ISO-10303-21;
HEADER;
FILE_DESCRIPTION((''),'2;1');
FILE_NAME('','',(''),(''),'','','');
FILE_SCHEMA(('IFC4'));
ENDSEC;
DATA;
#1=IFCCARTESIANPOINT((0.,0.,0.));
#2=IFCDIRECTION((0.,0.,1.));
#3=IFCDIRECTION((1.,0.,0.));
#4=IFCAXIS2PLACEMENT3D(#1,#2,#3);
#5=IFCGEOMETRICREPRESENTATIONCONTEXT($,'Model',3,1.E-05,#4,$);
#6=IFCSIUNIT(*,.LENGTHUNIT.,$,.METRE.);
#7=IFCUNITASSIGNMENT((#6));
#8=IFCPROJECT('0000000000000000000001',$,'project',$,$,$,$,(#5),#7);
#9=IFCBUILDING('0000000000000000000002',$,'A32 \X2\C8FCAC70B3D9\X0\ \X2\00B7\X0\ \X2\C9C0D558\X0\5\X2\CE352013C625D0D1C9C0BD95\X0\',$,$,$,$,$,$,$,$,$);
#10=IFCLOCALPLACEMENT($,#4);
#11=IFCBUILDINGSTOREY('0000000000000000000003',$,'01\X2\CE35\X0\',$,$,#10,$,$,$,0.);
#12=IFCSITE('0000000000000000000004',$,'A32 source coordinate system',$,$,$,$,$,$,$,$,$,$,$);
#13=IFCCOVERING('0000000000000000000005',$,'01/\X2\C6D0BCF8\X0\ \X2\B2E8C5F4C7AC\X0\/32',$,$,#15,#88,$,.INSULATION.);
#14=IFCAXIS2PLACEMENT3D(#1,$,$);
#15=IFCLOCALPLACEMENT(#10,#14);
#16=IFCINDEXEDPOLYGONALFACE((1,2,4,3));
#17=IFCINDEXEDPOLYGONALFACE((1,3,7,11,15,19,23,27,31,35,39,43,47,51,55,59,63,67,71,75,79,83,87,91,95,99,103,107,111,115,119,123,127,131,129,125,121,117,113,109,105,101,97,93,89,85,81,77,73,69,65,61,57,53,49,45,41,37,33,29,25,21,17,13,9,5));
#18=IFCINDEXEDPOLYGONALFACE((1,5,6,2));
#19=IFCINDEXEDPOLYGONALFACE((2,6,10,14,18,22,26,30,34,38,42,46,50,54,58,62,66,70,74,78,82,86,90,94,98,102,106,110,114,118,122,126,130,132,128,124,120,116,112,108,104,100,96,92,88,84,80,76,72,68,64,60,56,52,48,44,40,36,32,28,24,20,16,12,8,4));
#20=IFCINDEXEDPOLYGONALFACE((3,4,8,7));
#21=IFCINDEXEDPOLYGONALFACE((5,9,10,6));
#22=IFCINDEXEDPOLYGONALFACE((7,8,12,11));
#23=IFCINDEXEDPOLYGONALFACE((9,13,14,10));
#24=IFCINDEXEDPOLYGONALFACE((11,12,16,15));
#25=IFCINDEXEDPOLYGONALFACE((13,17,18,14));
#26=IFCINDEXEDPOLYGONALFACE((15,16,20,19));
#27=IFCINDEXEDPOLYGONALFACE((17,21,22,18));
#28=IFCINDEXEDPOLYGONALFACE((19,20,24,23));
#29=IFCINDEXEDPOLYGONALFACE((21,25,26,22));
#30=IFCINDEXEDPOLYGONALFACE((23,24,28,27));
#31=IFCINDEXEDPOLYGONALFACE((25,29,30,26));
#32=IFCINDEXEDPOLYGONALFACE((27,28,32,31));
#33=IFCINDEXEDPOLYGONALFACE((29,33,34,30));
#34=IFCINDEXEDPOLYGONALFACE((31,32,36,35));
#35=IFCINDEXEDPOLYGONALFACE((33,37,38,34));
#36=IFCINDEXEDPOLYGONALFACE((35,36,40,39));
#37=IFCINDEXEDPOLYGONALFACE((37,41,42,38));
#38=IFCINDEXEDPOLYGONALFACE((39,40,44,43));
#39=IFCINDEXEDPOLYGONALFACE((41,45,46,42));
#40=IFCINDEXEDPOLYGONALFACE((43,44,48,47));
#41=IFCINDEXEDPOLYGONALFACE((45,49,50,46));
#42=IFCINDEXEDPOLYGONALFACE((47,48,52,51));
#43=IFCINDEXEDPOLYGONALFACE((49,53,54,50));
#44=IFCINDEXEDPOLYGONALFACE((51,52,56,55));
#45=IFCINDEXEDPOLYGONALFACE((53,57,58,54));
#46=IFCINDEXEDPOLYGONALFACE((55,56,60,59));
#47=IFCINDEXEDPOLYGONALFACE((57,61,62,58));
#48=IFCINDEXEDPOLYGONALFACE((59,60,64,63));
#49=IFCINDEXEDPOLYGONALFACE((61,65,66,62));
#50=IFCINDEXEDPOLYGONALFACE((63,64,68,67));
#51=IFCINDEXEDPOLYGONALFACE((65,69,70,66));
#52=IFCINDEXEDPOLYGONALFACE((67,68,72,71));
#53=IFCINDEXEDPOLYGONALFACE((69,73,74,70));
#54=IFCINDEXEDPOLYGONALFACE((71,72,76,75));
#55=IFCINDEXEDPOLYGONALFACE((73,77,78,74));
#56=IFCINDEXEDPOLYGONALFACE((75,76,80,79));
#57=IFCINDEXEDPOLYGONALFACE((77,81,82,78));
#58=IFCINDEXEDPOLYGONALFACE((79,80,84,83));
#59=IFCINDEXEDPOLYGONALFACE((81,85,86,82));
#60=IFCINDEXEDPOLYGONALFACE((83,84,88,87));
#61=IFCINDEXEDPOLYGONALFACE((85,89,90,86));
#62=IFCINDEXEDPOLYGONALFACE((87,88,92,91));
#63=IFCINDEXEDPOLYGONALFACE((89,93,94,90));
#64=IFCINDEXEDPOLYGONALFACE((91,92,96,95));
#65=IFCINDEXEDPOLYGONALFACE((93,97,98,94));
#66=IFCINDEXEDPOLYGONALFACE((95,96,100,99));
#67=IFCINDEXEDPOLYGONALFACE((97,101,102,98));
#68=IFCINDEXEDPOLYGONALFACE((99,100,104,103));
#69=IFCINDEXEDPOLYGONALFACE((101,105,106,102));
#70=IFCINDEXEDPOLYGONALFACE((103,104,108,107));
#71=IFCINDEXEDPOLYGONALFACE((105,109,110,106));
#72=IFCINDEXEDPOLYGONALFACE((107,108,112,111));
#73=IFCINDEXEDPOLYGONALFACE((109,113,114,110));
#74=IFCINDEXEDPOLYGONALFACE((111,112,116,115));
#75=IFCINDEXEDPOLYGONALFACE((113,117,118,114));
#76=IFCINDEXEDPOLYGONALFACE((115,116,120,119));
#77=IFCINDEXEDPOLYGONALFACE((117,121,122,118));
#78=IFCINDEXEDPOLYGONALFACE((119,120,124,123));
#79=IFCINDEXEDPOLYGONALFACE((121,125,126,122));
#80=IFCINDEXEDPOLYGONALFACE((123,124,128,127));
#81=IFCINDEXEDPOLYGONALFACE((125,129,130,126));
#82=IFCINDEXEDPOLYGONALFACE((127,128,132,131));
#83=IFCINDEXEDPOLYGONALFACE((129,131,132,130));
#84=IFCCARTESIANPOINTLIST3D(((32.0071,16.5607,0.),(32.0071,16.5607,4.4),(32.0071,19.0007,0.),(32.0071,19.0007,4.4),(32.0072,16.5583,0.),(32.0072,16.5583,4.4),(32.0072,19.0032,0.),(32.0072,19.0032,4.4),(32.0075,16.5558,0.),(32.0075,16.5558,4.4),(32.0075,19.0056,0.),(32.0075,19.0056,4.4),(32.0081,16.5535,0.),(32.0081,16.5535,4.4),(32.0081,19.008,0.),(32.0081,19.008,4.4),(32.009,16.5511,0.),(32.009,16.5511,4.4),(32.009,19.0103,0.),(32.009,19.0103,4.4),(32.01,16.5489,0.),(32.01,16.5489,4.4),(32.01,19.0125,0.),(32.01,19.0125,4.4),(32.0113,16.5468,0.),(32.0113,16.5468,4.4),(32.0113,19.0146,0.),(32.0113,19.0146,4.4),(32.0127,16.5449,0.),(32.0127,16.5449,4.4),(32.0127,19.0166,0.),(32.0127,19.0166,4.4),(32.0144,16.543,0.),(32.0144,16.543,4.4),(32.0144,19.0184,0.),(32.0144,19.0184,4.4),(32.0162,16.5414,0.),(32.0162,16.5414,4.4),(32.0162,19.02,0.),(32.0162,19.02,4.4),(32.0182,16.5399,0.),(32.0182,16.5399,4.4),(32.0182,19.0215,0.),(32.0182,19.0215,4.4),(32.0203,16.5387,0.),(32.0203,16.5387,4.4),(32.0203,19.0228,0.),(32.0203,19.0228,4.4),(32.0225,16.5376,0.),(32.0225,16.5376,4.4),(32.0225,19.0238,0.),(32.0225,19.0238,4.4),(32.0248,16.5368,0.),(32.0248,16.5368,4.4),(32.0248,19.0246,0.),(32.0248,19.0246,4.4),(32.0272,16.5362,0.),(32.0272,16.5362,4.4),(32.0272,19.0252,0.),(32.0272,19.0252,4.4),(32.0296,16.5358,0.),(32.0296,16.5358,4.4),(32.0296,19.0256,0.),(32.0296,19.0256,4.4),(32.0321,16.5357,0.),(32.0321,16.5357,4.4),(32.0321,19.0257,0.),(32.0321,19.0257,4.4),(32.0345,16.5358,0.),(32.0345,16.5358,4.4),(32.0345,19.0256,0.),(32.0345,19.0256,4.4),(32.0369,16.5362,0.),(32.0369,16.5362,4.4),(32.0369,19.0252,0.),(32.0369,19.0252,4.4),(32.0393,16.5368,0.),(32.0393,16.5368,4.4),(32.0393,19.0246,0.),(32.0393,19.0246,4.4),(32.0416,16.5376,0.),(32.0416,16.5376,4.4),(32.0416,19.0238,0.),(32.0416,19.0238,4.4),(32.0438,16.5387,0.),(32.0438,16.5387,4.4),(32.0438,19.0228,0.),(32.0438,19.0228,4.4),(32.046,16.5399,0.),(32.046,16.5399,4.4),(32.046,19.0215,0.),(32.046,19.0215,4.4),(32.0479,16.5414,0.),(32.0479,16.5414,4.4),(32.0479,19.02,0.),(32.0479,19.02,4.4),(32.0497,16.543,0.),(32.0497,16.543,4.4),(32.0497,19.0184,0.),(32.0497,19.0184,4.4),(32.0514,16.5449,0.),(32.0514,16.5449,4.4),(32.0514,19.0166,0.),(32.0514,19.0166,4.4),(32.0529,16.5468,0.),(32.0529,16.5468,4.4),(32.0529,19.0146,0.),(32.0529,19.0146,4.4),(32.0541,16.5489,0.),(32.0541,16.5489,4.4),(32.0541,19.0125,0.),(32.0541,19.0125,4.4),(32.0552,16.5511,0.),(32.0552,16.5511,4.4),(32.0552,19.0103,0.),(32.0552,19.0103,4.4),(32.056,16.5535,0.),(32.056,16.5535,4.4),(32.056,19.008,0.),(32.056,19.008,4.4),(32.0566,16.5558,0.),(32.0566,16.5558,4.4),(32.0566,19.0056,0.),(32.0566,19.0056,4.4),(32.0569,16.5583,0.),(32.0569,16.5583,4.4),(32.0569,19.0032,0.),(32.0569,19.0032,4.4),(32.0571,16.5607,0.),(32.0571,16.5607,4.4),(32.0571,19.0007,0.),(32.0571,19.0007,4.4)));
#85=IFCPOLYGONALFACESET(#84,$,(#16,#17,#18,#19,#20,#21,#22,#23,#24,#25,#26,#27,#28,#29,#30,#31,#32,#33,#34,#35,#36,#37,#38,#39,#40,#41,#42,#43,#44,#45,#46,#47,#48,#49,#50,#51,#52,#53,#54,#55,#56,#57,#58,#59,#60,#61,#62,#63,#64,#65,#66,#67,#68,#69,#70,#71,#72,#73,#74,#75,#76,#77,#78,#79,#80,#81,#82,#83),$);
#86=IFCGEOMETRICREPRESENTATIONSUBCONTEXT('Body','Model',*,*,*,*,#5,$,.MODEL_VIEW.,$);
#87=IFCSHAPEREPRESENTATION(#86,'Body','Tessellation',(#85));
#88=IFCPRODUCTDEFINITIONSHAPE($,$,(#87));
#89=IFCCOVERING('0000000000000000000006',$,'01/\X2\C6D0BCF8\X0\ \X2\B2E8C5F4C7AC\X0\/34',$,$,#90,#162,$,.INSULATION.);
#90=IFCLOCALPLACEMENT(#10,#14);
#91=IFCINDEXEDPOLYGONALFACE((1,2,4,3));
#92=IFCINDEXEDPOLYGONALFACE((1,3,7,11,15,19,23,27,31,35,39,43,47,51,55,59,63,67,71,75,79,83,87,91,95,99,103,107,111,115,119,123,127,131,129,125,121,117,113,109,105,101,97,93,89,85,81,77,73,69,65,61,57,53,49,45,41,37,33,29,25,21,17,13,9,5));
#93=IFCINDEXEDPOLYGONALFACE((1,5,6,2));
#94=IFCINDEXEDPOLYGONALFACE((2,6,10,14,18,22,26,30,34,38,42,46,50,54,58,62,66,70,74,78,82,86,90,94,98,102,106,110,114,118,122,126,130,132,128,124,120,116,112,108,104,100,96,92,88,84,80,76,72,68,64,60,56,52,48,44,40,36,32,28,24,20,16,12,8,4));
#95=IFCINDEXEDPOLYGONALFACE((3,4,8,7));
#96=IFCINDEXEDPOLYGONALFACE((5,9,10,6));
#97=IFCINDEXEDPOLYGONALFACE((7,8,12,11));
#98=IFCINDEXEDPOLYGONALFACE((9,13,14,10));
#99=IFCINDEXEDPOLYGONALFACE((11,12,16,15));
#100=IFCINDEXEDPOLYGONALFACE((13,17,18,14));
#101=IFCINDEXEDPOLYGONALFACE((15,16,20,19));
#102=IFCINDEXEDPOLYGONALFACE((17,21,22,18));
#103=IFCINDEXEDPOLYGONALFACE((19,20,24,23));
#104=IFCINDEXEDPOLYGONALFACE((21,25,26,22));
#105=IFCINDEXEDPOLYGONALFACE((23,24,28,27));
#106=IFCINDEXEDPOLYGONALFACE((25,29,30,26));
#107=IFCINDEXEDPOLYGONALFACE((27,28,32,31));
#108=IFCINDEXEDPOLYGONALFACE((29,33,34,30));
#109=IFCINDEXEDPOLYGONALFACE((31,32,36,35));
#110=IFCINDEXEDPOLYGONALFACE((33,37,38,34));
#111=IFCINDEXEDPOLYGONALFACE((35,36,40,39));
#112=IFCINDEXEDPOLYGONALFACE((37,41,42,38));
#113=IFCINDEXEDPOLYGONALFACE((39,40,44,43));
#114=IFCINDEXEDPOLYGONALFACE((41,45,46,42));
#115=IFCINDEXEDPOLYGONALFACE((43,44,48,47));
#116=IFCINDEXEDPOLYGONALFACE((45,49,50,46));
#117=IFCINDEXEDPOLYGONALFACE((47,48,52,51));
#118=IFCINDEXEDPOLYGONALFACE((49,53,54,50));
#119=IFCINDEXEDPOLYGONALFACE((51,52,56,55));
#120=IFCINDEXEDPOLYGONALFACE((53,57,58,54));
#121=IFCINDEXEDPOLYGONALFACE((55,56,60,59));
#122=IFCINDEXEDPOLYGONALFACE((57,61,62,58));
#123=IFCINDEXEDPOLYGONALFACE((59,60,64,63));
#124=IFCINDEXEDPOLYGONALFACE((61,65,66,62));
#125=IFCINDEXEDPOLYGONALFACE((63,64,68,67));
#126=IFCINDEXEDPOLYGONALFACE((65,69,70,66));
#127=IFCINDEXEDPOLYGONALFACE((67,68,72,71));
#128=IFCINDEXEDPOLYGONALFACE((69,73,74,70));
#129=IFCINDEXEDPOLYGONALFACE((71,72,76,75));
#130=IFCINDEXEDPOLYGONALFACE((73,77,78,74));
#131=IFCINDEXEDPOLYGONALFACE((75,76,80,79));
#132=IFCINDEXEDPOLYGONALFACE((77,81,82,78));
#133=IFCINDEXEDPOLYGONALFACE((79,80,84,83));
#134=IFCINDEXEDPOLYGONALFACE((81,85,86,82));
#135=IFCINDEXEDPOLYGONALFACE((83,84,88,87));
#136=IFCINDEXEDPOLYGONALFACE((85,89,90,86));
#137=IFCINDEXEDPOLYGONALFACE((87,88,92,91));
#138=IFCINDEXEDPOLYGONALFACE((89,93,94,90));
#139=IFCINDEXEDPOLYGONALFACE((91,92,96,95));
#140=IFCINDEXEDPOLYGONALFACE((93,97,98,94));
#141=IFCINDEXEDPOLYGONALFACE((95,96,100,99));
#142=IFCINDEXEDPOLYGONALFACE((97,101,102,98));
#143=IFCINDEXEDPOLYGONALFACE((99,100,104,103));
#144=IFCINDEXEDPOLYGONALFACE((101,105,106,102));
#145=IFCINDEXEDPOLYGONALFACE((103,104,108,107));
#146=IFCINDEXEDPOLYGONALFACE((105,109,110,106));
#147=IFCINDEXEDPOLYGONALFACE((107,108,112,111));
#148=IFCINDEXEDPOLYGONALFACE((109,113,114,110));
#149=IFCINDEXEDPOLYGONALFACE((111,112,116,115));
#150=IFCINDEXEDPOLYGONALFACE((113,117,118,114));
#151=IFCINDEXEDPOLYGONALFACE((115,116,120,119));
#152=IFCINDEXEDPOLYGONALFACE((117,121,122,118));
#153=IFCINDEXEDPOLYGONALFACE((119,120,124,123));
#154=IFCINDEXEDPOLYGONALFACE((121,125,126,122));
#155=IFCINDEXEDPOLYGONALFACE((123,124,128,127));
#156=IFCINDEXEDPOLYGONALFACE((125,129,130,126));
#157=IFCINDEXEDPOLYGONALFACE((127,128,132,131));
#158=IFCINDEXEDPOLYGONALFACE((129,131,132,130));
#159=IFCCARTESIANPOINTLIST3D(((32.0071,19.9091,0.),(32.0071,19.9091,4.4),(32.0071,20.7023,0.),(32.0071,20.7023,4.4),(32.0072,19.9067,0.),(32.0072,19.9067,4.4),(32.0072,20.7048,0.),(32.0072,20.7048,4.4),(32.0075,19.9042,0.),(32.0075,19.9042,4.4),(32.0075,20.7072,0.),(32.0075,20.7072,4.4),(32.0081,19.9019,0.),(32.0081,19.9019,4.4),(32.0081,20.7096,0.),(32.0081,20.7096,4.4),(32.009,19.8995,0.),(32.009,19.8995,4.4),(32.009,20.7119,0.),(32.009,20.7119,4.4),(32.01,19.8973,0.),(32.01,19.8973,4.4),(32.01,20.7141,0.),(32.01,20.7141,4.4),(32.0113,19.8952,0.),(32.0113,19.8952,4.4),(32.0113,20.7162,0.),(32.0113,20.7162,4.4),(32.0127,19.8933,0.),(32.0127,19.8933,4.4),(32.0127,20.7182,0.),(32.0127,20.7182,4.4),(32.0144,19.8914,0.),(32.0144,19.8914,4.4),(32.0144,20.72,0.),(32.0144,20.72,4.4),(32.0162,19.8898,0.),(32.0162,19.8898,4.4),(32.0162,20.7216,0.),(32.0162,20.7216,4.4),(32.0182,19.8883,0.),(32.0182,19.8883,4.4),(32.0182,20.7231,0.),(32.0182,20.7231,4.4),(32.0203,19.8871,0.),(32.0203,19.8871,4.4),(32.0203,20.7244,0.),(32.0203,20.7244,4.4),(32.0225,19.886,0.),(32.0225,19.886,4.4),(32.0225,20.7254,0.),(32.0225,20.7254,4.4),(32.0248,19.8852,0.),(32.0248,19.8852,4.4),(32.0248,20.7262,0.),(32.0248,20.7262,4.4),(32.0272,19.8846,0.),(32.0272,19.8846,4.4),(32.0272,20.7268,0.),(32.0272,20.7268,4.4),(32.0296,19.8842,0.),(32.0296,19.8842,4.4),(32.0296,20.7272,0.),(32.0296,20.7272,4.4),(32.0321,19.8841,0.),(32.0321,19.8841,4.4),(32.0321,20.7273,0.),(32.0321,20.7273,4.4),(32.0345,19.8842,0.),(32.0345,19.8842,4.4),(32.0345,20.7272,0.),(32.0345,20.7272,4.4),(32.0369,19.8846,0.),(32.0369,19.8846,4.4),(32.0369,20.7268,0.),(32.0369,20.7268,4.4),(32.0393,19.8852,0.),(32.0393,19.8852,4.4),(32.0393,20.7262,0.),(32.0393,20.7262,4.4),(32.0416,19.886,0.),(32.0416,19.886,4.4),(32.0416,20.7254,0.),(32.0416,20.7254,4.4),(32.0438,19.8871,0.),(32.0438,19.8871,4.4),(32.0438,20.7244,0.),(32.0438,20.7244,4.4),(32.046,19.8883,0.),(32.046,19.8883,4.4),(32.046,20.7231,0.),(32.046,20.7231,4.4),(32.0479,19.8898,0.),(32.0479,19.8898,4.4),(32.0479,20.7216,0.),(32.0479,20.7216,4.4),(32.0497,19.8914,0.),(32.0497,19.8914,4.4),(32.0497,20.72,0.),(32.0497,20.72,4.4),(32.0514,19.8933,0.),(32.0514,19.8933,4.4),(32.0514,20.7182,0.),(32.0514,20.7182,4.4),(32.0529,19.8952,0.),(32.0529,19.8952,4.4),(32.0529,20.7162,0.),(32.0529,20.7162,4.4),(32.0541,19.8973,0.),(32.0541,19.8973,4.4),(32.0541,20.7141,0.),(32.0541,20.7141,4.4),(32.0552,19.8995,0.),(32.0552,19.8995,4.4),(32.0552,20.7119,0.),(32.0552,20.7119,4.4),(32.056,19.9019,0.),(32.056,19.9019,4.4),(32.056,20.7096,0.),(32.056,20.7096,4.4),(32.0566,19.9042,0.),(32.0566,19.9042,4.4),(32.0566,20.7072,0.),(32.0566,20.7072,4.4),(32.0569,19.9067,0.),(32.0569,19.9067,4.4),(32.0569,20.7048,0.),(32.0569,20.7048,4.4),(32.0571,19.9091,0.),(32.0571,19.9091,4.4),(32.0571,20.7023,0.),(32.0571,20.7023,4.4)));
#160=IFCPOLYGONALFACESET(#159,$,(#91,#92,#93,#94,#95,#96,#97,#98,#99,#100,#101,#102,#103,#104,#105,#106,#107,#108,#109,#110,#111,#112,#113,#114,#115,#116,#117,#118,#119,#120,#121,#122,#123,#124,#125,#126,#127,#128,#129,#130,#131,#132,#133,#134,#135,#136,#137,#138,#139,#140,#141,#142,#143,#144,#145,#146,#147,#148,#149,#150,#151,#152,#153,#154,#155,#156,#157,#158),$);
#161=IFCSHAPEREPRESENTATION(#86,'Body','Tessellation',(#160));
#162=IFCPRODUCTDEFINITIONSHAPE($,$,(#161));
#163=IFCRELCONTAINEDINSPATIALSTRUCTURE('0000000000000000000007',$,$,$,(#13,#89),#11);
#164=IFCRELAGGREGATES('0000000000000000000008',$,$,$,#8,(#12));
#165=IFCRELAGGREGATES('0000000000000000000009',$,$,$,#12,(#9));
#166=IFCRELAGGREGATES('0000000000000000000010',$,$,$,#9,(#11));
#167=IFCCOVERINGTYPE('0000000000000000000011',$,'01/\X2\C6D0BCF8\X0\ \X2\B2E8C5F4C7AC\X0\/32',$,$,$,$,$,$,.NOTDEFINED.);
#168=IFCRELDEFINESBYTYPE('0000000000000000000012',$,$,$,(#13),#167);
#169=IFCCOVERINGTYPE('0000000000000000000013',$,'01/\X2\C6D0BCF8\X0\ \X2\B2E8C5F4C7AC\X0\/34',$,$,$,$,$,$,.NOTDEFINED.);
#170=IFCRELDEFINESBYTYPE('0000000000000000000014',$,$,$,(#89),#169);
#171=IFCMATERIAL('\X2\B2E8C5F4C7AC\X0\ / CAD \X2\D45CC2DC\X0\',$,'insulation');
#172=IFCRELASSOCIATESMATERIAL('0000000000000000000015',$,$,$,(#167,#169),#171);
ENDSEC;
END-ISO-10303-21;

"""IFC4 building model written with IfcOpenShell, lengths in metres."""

from ifc_helpers import new_model, si_unit, origin, origin_with_axes, place, context, subcontext, project, spatial, polyline, outline, extrude, source, transform, mapped, material, type_object, type_shapes, element, save


model = new_model("IFC4")

# Units and contexts
model_context = context("Model", 3, precision=1e-05, world=origin_with_axes())
body_context = subcontext(model_context, "Body", "Model", "MODEL_VIEW")
ifc_project = project(units=[si_unit("LENGTHUNIT", "METRE")], contexts=[model_context])

# Site, building, storey
site = spatial("IfcSite", under=ifc_project, Name="A32 source coordinate system")
building = spatial("IfcBuilding", under=site, Name="A32 주거동 · 지하5층–옥탑지붕")
storey_placement = place(None, origin_with_axes())
storey = spatial("IfcBuildingStorey", under=building, at=storey_placement, Name="01층", Elevation=0.0)

# Coverings
ifc_material = material(Name="단열재 / CAD 표시", Category="insulation")
covering_type_1 = type_object("IfcCoveringType", Name="01/원본 단열재/32", PredefinedType="NOTDEFINED", material=ifc_material)
shared_shape_1 = source(origin(), body_context, "Body", "SweptSolid", [
    extrude(outline(polyline([(32.0541, 16.5489), (32.0529, 16.5468), (32.0514, 16.5449), (32.0497, 16.543), (32.0479, 16.5414), (32.046, 16.5399), (32.0438, 16.5387), (32.0416, 16.5376), (32.0393, 16.5368), (32.0369, 16.5362), (32.0345, 16.5358), (32.0321, 16.5357), (32.0296, 16.5358), (32.0272, 16.5362), (32.0248, 16.5368), (32.0225, 16.5376), (32.0203, 16.5387), (32.0182, 16.5399), (32.0162, 16.5414), (32.0144, 16.543), (32.0127, 16.5449), (32.0113, 16.5468), (32.01, 16.5489), (32.009, 16.5511), (32.0081, 16.5535), (32.0075, 16.5558), (32.0072, 16.5583), (32.0071, 16.5607), (32.0071, 19.0007), (32.0072, 19.0032), (32.0075, 19.0056), (32.0081, 19.008), (32.009, 19.0103), (32.01, 19.0125), (32.0113, 19.0146), (32.0127, 19.0166), (32.0144, 19.0184), (32.0162, 19.02), (32.0182, 19.0215), (32.0203, 19.0228), (32.0225, 19.0238), (32.0248, 19.0246), (32.0272, 19.0252), (32.0296, 19.0256), (32.0321, 19.0257), (32.0345, 19.0256), (32.0369, 19.0252), (32.0393, 19.0246), (32.0416, 19.0238), (32.0438, 19.0228), (32.046, 19.0215), (32.0479, 19.02), (32.0497, 19.0184), (32.0514, 19.0166), (32.0529, 19.0146), (32.0541, 19.0125), (32.0552, 19.0103), (32.056, 19.008), (32.0566, 19.0056), (32.0569, 19.0032), (32.0571, 19.0007), (32.0571, 16.5607), (32.0569, 16.5583), (32.0566, 16.5558), (32.056, 16.5535), (32.0552, 16.5511), (32.0541, 16.5489)])), origin(), (0.0, 0.0, 1.0), 4.4),
])
type_shapes(covering_type_1, [shared_shape_1])
covering_1_placement = place(storey_placement, origin_with_axes())
element("IfcCovering", 1, at=covering_1_placement, inside=storey, type_object=covering_type_1, Name="01/원본 단열재/32", PredefinedType="INSULATION", context=body_context, shape_type="MappedRepresentation", body=[
    mapped(shared_shape_1, transform((0.0, 0.0, 0.0), scale=1.0)),
])
covering_type_2 = type_object("IfcCoveringType", Name="01/원본 단열재/34", PredefinedType="NOTDEFINED", material=ifc_material)
shared_shape_2 = source(origin(), body_context, "Body", "SweptSolid", [
    extrude(outline(polyline([(32.0113, 20.7162), (32.0127, 20.7182), (32.0144, 20.72), (32.0162, 20.7216), (32.0182, 20.7231), (32.0203, 20.7244), (32.0225, 20.7254), (32.0248, 20.7262), (32.0272, 20.7268), (32.0296, 20.7272), (32.0321, 20.7273), (32.0345, 20.7272), (32.0369, 20.7268), (32.0393, 20.7262), (32.0416, 20.7254), (32.0438, 20.7244), (32.046, 20.7231), (32.0479, 20.7216), (32.0497, 20.72), (32.0514, 20.7182), (32.0529, 20.7162), (32.0541, 20.7141), (32.0552, 20.7119), (32.056, 20.7096), (32.0566, 20.7072), (32.0569, 20.7048), (32.0571, 20.7023), (32.0571, 19.9091), (32.0569, 19.9067), (32.0566, 19.9042), (32.056, 19.9019), (32.0552, 19.8995), (32.0541, 19.8973), (32.0529, 19.8952), (32.0514, 19.8933), (32.0497, 19.8914), (32.0479, 19.8898), (32.046, 19.8883), (32.0438, 19.8871), (32.0416, 19.886), (32.0393, 19.8852), (32.0369, 19.8846), (32.0345, 19.8842), (32.0321, 19.8841), (32.0296, 19.8842), (32.0272, 19.8846), (32.0248, 19.8852), (32.0225, 19.886), (32.0203, 19.8871), (32.0182, 19.8883), (32.0162, 19.8898), (32.0144, 19.8914), (32.0127, 19.8933), (32.0113, 19.8952), (32.01, 19.8973), (32.009, 19.8995), (32.0081, 19.9019), (32.0075, 19.9042), (32.0072, 19.9067), (32.0071, 19.9091), (32.0071, 20.7023), (32.0072, 20.7048), (32.0075, 20.7072), (32.0081, 20.7096), (32.009, 20.7119), (32.01, 20.7141), (32.0113, 20.7162)])), origin(), (0.0, 0.0, 1.0), 4.4),
])
type_shapes(covering_type_2, [shared_shape_2])
covering_2_placement = place(storey_placement, origin_with_axes())
element("IfcCovering", 2, at=covering_2_placement, inside=storey, type_object=covering_type_2, Name="01/원본 단열재/34", PredefinedType="INSULATION", context=body_context, shape_type="MappedRepresentation", body=[
    mapped(shared_shape_2, transform((0.0, 0.0, 0.0), scale=1.0)),
])

save(model, "model.ifc")
